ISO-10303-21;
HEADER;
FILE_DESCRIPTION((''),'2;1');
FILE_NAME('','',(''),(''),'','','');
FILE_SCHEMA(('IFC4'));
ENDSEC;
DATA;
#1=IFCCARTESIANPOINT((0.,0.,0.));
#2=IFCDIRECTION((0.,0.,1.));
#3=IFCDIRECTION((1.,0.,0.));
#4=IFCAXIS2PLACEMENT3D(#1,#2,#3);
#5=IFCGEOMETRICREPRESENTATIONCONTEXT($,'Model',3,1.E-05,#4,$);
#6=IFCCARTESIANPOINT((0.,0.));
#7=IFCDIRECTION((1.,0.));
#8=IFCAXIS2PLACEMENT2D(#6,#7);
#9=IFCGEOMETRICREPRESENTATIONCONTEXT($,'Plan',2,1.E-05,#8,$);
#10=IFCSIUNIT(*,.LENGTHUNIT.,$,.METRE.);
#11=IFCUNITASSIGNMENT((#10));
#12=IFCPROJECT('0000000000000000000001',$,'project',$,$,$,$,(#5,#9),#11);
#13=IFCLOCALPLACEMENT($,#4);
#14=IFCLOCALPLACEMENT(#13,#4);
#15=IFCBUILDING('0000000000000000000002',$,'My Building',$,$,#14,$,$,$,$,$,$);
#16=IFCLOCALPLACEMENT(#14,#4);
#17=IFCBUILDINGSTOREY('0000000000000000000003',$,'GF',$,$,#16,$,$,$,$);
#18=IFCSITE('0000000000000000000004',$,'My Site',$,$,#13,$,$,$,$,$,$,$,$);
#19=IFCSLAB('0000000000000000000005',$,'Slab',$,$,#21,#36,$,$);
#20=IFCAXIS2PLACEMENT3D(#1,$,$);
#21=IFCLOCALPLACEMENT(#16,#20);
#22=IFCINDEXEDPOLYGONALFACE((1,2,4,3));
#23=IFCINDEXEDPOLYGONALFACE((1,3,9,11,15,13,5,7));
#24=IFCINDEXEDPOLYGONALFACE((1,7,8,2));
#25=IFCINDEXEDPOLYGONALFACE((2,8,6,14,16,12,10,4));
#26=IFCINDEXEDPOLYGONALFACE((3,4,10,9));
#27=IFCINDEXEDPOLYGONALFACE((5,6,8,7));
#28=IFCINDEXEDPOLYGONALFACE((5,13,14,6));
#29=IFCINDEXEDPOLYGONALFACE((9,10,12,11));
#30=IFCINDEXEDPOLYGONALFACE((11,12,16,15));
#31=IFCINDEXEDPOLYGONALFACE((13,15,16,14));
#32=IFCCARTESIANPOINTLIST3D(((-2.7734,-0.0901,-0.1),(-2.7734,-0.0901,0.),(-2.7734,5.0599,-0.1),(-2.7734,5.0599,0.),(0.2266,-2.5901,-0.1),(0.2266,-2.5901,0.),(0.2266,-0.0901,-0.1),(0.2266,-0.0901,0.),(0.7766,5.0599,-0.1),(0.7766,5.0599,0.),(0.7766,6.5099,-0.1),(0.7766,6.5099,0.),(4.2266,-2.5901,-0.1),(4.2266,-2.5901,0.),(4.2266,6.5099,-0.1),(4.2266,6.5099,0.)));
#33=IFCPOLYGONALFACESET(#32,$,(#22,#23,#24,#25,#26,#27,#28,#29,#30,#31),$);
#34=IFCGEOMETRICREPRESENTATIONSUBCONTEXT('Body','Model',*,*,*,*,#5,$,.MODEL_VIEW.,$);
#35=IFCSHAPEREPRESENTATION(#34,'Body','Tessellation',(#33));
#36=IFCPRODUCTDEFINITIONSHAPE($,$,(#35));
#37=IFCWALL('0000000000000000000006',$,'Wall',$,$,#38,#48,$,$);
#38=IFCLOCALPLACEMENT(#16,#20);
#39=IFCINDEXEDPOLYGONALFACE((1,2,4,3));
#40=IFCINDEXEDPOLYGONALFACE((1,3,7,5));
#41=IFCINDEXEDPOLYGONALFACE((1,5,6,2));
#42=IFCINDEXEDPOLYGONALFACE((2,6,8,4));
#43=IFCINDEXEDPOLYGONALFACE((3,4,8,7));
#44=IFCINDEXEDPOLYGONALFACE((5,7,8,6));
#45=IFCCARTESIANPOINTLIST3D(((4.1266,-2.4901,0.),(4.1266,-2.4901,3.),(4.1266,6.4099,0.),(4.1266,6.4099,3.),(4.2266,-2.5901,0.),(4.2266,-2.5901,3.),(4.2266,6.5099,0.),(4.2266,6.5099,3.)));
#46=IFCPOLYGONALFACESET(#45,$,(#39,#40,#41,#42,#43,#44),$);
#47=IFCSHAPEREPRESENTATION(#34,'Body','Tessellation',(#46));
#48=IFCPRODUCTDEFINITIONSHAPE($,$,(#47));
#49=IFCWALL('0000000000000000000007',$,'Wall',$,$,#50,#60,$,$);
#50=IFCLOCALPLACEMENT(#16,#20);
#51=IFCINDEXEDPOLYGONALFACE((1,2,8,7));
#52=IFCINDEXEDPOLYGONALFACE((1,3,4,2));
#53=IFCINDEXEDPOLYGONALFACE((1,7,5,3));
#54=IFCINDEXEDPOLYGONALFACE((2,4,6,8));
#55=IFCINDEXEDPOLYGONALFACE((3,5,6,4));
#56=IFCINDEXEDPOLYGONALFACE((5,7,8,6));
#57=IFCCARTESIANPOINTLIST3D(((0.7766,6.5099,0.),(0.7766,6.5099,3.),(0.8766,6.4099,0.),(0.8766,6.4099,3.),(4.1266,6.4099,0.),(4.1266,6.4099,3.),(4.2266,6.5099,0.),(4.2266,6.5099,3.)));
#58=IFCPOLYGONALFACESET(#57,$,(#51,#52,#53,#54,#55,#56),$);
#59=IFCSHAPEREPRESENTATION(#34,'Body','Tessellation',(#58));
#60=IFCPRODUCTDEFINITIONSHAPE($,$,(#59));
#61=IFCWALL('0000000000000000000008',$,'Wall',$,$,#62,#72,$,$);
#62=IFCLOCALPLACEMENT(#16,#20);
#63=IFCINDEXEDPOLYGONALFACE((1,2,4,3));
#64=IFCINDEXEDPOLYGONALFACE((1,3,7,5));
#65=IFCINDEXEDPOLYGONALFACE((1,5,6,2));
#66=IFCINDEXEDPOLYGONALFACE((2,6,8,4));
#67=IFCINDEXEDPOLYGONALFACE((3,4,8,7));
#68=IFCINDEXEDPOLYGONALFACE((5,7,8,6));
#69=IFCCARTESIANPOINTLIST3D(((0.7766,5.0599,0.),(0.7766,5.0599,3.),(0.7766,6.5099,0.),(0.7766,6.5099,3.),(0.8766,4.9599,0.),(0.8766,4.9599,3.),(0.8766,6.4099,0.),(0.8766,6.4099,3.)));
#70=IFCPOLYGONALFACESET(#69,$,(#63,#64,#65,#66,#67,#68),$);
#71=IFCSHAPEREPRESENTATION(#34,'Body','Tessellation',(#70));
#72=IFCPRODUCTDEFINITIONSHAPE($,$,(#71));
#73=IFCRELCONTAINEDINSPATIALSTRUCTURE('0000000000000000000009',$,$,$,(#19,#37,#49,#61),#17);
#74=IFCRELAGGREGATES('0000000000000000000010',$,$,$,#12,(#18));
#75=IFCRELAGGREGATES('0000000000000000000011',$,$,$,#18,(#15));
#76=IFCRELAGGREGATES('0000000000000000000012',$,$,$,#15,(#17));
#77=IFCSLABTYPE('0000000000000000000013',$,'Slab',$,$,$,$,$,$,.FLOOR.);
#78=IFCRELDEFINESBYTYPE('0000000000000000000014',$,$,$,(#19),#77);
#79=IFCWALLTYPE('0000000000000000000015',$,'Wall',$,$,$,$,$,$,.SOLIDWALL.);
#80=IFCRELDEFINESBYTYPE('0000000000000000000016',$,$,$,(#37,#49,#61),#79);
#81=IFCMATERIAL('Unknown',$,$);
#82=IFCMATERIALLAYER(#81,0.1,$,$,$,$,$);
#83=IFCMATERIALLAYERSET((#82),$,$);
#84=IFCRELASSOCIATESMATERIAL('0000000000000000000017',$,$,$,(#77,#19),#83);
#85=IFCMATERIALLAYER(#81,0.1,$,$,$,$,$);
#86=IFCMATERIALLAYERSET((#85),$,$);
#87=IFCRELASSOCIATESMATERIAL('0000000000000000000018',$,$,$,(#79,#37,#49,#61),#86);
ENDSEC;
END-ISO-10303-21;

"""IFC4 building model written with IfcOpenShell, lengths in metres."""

from ifc_helpers import new_model, si_unit, frame, origin_with_axes, origin_2d_with_axis, place, context, subcontext, project, spatial, line, indexed_curve, outline, extrude, material, layer, layer_set, layer_usage, type_object, element, save


model = new_model("IFC4")

# Units and contexts
model_context = context("Model", 3, precision=1e-05, world=origin_with_axes())
plan_context = context("Plan", 2, precision=1e-05, world=origin_2d_with_axis())
body_context_1 = subcontext(model_context, "Body", "Model", "MODEL_VIEW")
ifc_project = project(units=[si_unit("LENGTHUNIT", "METRE")], contexts=[model_context, plan_context])

# Site, building, storey
site_placement = place(None, origin_with_axes())
site = spatial("IfcSite", under=ifc_project, at=site_placement, Name="My Site")
building_placement = place(site_placement, origin_with_axes())
building = spatial("IfcBuilding", under=site, at=building_placement, Name="My Building")
storey_placement = place(building_placement, origin_with_axes())
storey = spatial("IfcBuildingStorey", under=building, at=storey_placement, Name="GF")

# Slab
ifc_material = material(Name="Unknown")
ifc_layer_1 = layer(ifc_material, 0.1)
ifc_layer_set_1 = layer_set([ifc_layer_1])
ifc_layer_usage_1 = layer_usage(ifc_layer_set_1, "AXIS3", "POSITIVE", -0.1)
slab_type = type_object("IfcSlabType", Name="Slab", PredefinedType="FLOOR", material=ifc_layer_set_1)
slab_placement = place(storey_placement, frame((4.2266, -2.5901, 0.0), z_axis=(0.0, 0.0, 1.0), x_axis=(1.0, 0.0, 0.0)))
element("IfcSlab", 1, at=slab_placement, inside=storey, type_object=slab_type, material=ifc_layer_usage_1, Name="Slab", context=body_context_1, shape_type="SweptSolid", body=[
    extrude(outline(indexed_curve([(0.0, 0.0), (0.0, 9.1), (-3.45, 9.1), (-3.45, 7.65), (-7.0, 7.65), (-7.0, 2.5), (-4.0, 2.5), (-4.0, 0.0), (0.0, 0.0)])), frame((0.0, 0.0, -0.1), z_axis=(0.0, 0.0, 1.0), x_axis=(1.0, 0.0, 0.0)), (0.0, 0.0, 1.0), 0.1),
])

# Shared definitions
ifc_layer_2 = layer(ifc_material, 0.1)
ifc_layer_set_2 = layer_set([ifc_layer_2])
wall_type = type_object("IfcWallType", Name="Wall", PredefinedType="SOLIDWALL", material=ifc_layer_set_2)

# Walls
ifc_layer_usage_2 = layer_usage(ifc_layer_set_2, "AXIS2", "POSITIVE", 0.0)
wall_1_placement = place(storey_placement, frame((4.2266, -2.5901, 0.0), z_axis=(0.0, 0.0, 1.0), x_axis=(0.0, 1.0, 0.0)))
element("IfcWall", 2, at=wall_1_placement, inside=storey, type_object=wall_type, material=ifc_layer_usage_2, Name="Wall", context=body_context_1, shape_type="SweptSolid", body=[
    extrude(outline(indexed_curve([(0.0, 0.0), (0.1, 0.1), (9.0, 0.1), (9.1, 0.0)], segments=[line(1, 2, 3, 4, 1)])), origin_with_axes(), (0.0, 0.0, 1.0), 3.0),
])
ifc_layer_usage_3 = layer_usage(ifc_layer_set_2, "AXIS2", "POSITIVE", 0.0)
wall_2_placement = place(storey_placement, frame((4.2266, 6.5099, 0.0), z_axis=(0.0, 0.0, 1.0), x_axis=(-1.0, 0.0, 0.0)))
element("IfcWall", 3, at=wall_2_placement, inside=storey, type_object=wall_type, material=ifc_layer_usage_3, Name="Wall", context=body_context_1, shape_type="SweptSolid", body=[
    extrude(outline(indexed_curve([(0.0, 0.0), (0.1, 0.1), (3.35, 0.1), (3.45, 0.0)], segments=[line(1, 2, 3, 4, 1)])), origin_with_axes(), (0.0, 0.0, 1.0), 3.0),
])
ifc_layer_usage_4 = layer_usage(ifc_layer_set_2, "AXIS2", "POSITIVE", 0.0)
wall_3_placement = place(storey_placement, frame((0.7766, 6.5099, 0.0), z_axis=(0.0, 0.0, 1.0), x_axis=(0.0, -1.0, 0.0)))
element("IfcWall", 4, at=wall_3_placement, inside=storey, type_object=wall_type, material=ifc_layer_usage_4, Name="Wall", context=body_context_1, shape_type="SweptSolid", body=[
    extrude(outline(indexed_curve([(0.0, 0.0), (0.1, 0.1), (1.55, 0.1), (1.45, 0.0)], segments=[line(1, 2, 3, 4, 1)])), origin_with_axes(), (0.0, 0.0, 1.0), 3.0),
])

save(model, "model.ifc")
